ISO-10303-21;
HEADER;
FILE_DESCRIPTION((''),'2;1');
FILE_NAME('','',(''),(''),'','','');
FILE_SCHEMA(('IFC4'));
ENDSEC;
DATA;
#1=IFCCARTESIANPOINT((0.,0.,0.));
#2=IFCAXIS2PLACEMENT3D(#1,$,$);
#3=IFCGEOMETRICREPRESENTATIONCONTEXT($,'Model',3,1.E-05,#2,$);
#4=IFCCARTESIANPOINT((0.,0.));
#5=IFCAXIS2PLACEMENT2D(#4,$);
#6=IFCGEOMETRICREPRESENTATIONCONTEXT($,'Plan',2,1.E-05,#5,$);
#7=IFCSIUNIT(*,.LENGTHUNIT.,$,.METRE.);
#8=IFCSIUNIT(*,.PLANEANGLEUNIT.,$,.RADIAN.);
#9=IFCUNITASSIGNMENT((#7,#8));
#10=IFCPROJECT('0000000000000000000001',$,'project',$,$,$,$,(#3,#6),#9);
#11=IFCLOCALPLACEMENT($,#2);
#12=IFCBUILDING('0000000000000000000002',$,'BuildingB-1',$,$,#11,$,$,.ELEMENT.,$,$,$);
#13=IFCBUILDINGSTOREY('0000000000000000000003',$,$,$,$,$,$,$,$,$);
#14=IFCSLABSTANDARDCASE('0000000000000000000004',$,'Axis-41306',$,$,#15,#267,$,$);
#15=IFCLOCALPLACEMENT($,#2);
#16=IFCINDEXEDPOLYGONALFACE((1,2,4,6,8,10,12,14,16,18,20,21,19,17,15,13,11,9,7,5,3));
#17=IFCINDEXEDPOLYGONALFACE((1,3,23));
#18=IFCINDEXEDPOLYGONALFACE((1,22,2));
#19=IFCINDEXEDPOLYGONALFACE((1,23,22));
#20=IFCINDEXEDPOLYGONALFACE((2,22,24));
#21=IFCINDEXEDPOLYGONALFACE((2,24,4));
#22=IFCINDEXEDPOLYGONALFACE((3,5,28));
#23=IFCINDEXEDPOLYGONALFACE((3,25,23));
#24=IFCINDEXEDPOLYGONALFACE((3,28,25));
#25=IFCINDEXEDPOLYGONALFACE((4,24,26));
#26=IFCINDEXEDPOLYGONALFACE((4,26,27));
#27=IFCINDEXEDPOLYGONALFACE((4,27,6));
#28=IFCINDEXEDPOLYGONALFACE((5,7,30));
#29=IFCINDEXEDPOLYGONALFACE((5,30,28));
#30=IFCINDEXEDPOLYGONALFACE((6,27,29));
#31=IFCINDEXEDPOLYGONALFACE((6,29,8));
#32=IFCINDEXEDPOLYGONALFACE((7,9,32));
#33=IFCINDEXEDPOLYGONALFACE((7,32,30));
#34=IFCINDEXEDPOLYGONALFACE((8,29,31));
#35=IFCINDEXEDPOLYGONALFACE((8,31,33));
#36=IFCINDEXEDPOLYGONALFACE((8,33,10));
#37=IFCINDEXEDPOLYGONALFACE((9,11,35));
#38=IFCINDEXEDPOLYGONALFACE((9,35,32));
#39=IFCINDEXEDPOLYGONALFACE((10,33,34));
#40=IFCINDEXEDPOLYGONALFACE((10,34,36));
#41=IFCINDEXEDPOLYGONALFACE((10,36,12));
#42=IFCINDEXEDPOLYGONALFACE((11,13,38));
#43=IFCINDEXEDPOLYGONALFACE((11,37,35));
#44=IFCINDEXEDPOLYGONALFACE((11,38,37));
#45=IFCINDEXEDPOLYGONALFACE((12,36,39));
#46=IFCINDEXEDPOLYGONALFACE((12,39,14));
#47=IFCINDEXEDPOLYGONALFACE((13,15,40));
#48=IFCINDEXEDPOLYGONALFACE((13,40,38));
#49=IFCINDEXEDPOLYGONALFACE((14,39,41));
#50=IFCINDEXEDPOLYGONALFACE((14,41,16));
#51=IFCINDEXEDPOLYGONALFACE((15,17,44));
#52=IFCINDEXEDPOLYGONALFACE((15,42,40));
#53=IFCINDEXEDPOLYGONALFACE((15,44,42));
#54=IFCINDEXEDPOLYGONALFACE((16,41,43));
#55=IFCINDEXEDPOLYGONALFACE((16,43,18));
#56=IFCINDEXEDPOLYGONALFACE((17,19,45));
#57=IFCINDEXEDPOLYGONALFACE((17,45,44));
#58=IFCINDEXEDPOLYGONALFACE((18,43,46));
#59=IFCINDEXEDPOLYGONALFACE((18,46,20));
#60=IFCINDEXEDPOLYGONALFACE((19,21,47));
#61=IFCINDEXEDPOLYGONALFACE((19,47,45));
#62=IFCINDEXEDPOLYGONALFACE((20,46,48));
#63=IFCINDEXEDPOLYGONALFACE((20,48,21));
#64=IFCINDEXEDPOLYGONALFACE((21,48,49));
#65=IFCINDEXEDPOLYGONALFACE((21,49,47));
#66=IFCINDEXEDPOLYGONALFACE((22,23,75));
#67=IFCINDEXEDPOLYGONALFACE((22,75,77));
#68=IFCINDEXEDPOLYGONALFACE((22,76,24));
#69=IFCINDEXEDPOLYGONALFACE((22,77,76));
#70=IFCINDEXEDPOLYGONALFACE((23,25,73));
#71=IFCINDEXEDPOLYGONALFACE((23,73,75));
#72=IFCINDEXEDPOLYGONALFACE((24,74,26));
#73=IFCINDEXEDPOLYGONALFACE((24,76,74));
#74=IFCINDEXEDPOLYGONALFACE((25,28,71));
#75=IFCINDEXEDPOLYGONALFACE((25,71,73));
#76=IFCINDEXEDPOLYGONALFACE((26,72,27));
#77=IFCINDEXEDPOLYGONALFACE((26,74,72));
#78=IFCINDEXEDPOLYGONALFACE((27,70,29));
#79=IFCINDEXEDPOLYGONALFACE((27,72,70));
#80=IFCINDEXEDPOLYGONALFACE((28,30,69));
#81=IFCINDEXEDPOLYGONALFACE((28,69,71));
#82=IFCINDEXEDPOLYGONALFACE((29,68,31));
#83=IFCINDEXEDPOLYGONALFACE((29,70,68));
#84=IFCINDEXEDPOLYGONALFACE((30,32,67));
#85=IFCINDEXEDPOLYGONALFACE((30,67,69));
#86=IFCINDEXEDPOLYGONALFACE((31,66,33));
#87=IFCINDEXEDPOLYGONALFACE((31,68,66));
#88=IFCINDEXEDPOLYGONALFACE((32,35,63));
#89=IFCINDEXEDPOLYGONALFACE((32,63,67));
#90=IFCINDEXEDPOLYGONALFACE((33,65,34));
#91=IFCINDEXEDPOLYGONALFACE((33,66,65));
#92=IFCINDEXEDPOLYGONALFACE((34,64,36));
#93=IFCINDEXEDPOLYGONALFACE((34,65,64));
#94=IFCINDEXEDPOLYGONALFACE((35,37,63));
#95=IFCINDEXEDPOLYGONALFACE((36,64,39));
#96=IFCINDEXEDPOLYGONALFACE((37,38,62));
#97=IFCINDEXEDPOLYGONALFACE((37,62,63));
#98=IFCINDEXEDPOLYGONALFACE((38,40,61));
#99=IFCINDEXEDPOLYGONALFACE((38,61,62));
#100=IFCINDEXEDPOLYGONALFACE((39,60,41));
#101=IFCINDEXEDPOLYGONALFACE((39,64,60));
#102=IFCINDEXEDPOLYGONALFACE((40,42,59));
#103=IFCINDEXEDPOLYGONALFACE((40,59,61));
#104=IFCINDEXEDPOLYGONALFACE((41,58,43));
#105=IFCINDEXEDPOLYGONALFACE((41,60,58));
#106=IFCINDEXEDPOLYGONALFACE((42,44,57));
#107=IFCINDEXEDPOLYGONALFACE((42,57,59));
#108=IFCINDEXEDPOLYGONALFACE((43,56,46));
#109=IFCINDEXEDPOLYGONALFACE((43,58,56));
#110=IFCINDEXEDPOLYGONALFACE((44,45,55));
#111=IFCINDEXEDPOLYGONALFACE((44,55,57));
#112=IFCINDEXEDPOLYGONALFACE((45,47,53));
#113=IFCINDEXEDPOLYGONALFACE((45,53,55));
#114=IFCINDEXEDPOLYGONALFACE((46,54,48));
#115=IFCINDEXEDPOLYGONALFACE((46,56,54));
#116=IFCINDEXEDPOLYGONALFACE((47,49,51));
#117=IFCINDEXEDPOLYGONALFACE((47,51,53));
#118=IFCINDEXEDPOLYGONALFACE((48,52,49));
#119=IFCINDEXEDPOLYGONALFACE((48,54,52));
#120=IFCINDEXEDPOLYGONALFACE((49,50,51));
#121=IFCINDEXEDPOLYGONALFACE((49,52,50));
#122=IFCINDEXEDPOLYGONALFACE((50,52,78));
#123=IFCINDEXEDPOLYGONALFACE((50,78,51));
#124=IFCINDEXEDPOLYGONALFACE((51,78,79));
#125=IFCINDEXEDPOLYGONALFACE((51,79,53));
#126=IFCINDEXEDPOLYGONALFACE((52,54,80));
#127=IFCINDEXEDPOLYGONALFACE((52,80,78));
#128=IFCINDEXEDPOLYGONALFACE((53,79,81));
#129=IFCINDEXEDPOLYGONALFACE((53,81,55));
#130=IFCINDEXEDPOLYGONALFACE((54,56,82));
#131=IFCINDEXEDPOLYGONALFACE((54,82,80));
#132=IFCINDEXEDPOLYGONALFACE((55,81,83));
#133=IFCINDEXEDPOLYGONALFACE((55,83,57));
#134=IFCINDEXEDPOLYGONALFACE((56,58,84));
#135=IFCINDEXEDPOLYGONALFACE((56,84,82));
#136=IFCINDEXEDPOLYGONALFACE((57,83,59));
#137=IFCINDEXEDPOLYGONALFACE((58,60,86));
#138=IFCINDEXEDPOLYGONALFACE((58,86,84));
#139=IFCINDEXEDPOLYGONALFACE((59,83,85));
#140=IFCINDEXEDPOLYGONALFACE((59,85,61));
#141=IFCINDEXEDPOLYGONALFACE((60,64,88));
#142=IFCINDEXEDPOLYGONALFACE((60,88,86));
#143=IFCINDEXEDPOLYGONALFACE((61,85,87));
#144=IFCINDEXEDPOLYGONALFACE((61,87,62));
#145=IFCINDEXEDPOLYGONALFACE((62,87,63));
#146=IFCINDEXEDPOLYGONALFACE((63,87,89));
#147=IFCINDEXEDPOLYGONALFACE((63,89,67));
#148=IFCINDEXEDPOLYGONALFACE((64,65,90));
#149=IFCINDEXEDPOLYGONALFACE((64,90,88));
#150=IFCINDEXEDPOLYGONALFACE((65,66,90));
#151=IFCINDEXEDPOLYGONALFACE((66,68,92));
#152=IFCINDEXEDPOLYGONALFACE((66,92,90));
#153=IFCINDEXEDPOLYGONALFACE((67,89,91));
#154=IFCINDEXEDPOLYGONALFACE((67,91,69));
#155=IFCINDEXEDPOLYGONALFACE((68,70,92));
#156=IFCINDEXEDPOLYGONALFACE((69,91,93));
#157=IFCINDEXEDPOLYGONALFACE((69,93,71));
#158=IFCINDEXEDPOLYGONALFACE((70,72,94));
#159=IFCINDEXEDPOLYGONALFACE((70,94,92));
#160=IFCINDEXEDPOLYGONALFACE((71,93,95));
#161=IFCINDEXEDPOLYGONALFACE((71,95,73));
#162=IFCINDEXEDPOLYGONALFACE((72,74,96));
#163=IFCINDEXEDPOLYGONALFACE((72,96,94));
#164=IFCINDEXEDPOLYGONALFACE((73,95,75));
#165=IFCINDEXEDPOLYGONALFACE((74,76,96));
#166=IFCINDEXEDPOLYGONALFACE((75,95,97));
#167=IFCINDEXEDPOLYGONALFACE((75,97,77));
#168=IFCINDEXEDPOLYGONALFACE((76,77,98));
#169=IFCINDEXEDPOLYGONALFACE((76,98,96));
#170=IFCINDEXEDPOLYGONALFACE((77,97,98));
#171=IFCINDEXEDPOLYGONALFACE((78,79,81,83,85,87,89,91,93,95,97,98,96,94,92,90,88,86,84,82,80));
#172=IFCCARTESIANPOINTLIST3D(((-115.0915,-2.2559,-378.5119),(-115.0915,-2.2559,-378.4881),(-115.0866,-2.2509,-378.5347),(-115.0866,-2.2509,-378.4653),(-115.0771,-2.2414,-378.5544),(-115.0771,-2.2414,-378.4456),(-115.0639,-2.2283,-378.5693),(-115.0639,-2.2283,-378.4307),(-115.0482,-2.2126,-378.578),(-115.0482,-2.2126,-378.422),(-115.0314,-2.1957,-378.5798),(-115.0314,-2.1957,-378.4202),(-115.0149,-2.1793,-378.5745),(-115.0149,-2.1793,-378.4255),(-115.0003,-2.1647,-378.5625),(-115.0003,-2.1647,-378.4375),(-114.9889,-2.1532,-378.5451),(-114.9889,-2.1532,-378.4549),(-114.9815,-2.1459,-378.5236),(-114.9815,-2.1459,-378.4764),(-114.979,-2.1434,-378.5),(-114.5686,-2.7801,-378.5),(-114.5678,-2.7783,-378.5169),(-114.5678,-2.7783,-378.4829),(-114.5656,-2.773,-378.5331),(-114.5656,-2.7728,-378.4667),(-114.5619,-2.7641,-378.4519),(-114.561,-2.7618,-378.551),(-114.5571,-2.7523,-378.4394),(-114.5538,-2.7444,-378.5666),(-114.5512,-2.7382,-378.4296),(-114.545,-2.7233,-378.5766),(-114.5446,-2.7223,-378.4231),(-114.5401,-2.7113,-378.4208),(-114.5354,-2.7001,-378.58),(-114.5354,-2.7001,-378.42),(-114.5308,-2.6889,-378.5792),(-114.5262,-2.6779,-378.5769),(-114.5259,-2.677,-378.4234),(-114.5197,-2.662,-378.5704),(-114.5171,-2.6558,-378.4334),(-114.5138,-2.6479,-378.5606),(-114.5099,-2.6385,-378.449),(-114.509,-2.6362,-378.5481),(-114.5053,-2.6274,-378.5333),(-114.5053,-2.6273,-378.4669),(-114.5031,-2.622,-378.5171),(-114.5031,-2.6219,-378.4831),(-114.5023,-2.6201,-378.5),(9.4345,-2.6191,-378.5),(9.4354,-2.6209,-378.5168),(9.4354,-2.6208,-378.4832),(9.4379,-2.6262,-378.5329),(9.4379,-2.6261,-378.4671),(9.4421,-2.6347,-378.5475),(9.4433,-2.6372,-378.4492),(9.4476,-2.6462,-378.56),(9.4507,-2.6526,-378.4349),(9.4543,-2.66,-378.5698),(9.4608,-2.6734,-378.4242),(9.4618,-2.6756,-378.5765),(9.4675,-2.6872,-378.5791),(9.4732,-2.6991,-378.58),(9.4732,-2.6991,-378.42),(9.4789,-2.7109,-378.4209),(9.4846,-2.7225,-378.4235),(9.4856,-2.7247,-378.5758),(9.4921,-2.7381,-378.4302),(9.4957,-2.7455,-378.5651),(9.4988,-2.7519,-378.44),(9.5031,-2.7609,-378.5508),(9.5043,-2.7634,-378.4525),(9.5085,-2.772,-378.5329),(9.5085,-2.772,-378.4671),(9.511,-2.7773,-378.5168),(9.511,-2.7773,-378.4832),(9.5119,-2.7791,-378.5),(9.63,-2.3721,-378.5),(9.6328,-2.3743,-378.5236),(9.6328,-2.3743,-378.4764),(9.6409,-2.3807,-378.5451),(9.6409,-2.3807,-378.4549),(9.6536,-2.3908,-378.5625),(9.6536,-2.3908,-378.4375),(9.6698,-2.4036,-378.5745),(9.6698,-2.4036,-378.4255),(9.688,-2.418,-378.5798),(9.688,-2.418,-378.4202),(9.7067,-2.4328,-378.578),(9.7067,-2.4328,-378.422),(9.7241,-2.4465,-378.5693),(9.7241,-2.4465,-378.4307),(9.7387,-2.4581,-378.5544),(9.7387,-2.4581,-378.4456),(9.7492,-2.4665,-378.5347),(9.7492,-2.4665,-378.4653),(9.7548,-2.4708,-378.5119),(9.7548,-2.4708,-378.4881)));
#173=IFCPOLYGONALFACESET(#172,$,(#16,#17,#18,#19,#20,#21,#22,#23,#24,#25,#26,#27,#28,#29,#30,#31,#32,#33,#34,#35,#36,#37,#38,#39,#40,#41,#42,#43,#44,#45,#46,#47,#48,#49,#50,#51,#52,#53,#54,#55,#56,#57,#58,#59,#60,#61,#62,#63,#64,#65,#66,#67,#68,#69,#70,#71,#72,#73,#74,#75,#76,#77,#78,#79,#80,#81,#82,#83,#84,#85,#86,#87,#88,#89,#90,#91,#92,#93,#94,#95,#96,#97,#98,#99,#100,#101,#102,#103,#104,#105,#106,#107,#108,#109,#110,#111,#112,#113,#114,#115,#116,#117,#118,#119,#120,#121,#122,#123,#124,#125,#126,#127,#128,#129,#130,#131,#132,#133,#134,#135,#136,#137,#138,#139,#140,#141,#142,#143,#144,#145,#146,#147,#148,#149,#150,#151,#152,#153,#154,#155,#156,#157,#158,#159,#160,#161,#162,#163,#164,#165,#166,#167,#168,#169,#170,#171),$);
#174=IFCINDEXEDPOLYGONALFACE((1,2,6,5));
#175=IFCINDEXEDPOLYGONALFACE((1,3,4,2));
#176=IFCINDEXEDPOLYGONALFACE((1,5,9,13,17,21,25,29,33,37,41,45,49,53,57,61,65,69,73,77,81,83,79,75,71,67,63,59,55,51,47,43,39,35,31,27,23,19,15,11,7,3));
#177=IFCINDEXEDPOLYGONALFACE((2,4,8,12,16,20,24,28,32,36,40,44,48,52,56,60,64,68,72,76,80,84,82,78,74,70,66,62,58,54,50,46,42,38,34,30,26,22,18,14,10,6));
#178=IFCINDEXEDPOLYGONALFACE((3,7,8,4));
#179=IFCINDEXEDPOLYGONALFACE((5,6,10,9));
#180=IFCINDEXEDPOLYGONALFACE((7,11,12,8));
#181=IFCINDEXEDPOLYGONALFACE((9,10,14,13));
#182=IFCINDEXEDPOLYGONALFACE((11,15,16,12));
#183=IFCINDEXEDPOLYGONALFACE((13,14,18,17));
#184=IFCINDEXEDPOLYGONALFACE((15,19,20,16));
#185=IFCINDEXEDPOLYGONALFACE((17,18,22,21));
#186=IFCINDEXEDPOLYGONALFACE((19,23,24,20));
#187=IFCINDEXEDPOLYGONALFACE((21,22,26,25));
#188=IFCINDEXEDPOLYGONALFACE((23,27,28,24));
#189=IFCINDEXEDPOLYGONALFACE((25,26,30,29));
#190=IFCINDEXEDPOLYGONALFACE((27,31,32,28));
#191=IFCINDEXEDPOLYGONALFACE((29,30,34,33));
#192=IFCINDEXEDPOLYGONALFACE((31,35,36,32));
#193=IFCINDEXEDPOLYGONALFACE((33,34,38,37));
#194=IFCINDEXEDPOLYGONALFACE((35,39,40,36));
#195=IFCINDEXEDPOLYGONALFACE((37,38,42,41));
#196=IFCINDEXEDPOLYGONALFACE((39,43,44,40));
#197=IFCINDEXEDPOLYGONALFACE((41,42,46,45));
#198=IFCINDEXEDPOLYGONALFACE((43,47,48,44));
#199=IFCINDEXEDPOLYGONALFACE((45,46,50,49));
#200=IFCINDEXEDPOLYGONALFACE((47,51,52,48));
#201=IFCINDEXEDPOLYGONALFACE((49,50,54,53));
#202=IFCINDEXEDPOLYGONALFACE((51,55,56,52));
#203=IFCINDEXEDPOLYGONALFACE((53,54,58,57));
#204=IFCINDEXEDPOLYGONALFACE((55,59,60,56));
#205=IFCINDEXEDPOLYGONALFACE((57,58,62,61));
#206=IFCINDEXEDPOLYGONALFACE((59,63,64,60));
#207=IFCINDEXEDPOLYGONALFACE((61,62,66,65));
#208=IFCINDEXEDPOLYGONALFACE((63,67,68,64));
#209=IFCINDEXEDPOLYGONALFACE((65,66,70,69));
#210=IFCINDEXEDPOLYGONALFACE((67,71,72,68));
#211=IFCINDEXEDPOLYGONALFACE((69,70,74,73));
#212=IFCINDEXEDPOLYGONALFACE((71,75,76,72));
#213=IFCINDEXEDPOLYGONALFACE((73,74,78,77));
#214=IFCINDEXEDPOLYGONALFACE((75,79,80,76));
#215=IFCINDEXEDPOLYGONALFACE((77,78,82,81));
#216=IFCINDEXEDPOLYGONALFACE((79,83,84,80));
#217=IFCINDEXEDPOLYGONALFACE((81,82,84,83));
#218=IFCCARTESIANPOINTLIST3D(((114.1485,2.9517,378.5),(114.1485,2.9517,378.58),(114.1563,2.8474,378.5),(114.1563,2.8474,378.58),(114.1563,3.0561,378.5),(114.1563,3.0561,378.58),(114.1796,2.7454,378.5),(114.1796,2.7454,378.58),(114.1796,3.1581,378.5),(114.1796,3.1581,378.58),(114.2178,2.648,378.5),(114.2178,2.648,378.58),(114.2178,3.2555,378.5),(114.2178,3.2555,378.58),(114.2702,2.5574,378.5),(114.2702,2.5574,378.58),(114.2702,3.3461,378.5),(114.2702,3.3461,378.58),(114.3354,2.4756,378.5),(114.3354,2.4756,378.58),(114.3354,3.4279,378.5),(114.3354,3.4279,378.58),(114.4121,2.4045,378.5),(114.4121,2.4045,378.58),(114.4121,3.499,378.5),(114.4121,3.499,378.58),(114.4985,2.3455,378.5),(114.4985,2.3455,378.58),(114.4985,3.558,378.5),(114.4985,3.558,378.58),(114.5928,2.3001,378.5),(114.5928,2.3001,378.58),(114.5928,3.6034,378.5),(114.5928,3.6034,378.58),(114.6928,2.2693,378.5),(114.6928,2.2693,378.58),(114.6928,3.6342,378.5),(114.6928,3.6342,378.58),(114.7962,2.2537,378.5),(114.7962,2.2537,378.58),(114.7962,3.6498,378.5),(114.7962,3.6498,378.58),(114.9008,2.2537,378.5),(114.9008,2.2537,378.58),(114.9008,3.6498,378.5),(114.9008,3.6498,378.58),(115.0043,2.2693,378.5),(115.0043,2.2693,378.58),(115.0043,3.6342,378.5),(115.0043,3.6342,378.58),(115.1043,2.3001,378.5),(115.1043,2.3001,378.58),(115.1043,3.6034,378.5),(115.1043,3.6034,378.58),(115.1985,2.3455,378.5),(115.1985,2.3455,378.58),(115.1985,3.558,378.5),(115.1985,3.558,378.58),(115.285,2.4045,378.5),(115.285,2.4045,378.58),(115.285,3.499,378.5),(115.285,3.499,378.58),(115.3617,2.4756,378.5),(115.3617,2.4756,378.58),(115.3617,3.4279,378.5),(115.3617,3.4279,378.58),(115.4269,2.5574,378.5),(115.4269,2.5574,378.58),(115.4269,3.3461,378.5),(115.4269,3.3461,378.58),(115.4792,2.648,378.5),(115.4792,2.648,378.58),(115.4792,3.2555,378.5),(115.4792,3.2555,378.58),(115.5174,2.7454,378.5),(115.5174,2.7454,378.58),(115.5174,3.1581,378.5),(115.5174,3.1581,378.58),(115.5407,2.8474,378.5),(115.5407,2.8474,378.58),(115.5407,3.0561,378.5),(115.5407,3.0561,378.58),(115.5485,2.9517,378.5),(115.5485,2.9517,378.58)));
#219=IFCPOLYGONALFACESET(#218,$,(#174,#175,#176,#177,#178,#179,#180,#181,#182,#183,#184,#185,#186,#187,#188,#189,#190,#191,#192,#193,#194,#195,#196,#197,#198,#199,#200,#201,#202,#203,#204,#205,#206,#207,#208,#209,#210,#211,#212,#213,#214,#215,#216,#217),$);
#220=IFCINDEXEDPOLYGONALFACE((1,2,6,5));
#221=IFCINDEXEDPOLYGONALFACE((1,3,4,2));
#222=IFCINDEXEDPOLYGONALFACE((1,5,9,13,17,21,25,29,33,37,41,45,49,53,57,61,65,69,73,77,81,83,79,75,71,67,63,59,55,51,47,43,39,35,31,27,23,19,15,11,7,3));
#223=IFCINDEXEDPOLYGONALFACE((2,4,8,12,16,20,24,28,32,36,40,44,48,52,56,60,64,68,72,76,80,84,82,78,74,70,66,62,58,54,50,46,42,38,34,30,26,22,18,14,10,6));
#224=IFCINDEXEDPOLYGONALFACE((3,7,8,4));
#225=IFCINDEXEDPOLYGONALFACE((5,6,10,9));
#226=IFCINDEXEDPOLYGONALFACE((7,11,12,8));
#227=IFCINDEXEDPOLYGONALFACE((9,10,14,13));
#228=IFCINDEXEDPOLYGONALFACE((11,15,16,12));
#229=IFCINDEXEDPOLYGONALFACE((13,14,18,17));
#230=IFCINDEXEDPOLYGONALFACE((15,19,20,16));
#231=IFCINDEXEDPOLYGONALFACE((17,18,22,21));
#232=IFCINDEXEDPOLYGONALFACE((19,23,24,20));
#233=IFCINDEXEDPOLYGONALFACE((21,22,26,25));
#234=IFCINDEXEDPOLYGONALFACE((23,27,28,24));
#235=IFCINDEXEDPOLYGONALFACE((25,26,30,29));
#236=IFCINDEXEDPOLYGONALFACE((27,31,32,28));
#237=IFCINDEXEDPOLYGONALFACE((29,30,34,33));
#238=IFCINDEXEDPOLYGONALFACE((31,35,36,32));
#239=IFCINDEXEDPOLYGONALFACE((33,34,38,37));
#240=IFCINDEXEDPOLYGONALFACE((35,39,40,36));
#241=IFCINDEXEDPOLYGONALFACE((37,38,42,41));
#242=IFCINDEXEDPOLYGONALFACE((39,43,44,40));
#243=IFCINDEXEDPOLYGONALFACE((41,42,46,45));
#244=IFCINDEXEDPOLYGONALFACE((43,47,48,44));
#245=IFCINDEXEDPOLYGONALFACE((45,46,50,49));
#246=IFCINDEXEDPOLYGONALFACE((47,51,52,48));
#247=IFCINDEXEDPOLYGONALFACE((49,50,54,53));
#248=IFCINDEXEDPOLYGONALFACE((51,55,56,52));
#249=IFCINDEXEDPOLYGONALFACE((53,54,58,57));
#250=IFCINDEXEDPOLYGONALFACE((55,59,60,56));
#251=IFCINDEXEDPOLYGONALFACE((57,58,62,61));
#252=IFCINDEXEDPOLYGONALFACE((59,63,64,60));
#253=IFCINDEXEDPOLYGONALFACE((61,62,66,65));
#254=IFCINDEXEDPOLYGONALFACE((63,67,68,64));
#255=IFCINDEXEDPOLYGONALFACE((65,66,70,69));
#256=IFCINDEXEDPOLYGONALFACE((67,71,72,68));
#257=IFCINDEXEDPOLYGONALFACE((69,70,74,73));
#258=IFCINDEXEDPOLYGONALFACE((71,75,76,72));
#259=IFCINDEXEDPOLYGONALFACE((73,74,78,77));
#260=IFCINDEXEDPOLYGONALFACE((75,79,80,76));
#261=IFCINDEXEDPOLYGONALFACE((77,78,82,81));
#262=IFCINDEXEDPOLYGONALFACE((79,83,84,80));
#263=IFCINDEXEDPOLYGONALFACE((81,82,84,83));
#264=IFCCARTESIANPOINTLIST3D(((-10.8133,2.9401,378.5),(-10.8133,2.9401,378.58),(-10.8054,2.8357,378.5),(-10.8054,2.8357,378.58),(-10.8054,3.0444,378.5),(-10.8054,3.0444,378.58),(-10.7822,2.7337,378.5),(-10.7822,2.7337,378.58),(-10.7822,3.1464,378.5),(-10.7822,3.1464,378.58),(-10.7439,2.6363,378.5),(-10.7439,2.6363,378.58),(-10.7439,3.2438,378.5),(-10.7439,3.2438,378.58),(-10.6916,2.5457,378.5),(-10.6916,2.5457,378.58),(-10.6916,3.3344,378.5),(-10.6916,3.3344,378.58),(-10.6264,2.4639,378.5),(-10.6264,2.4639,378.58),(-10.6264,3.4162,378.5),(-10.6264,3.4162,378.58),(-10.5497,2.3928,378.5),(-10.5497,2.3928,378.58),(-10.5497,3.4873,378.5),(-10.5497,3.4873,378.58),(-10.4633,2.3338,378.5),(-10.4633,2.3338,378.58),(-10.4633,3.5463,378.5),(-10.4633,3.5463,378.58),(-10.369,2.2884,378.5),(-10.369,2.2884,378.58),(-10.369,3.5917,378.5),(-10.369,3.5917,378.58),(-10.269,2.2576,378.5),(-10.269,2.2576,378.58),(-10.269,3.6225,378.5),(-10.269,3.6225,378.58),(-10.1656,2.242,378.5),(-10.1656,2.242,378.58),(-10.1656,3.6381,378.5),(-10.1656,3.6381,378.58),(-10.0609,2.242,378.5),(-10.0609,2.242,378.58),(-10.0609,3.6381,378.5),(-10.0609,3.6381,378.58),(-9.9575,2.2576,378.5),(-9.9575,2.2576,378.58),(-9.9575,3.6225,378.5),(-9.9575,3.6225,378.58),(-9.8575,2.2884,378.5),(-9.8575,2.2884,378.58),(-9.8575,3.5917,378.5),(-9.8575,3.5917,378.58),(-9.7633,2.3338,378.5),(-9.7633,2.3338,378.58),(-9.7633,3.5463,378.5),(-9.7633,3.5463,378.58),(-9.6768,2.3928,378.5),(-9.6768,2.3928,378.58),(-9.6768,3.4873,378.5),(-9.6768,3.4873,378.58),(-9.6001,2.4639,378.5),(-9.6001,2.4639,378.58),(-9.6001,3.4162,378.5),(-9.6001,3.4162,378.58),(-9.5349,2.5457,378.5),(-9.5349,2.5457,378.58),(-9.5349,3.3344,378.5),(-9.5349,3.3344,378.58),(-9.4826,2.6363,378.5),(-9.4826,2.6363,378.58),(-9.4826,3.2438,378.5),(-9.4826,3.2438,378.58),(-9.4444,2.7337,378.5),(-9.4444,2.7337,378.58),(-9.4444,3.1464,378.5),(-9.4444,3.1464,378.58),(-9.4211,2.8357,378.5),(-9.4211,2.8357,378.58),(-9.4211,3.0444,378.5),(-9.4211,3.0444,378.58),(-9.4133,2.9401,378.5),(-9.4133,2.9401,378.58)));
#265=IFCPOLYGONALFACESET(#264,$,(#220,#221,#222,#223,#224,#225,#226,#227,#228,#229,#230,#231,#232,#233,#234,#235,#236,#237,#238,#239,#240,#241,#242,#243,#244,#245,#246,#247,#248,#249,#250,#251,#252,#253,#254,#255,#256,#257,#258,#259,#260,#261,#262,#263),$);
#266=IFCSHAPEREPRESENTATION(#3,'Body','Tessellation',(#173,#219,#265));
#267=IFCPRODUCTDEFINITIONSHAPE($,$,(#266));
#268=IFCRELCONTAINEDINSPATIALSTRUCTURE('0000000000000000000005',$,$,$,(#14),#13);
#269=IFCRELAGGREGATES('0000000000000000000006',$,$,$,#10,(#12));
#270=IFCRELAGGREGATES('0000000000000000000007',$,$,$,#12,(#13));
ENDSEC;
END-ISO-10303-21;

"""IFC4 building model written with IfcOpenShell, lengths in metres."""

from ifc_helpers import new_model, entity, si_unit, frame, origin, origin_2d, place, context, project, spatial, circle, extrude, element, save


model = new_model("IFC4")

# Units and contexts
model_context = context("Model", 3, precision=1e-05, world=origin())
plan_context = context("Plan", 2, precision=1e-05, world=origin_2d())
ifc_project = project(units=[si_unit("LENGTHUNIT", "METRE"), si_unit("PLANEANGLEUNIT", "RADIAN")], contexts=[model_context, plan_context])

# Building, storey
building_placement = place(None, origin())
building = spatial("IfcBuilding", under=ifc_project, at=building_placement, Name="BuildingB-1", CompositionType="ELEMENT")
storey = spatial("IfcBuildingStorey", under=building)

# Slab
element("IfcSlabStandardCase", 1, inside=storey, Name="Axis-41306", context=model_context, shape_type="AdvancedSweptSolid", body=[
    entity("IfcSurfaceCurveSweptAreaSolid", entity("IfcCircleProfileDef", "AREA", None, None, 0.08), None, entity("IfcPolyline", [entity("IfcCartesianPoint", [114.8485, 2.7183, 378.5]), entity("IfcCartesianPoint", [114.629, 2.441, 378.5]), entity("IfcCartesianPoint", [-9.3797, 2.4399, 378.5]), entity("IfcCartesianPoint", [-9.8798, 2.9401, 378.5])]), None, None, entity("IfcPlane", entity("IfcAxis2Placement3D", entity("IfcCartesianPoint", [114.8485, 2.7183, 378.5]), entity("IfcDirection", [0.0, 0.0, 1.0]), entity("IfcDirection", [1.0, 0.0, 0.0])))),
    extrude(circle(Radius=0.7), frame((114.8485, 2.9517, 378.5)), (0.0, 0.0, 1.0), 0.08),
    extrude(circle(Radius=0.7), frame((-10.1133, 2.9401, 378.5)), (0.0, 0.0, 1.0), 0.08),
])

save(model, "model.ifc")
